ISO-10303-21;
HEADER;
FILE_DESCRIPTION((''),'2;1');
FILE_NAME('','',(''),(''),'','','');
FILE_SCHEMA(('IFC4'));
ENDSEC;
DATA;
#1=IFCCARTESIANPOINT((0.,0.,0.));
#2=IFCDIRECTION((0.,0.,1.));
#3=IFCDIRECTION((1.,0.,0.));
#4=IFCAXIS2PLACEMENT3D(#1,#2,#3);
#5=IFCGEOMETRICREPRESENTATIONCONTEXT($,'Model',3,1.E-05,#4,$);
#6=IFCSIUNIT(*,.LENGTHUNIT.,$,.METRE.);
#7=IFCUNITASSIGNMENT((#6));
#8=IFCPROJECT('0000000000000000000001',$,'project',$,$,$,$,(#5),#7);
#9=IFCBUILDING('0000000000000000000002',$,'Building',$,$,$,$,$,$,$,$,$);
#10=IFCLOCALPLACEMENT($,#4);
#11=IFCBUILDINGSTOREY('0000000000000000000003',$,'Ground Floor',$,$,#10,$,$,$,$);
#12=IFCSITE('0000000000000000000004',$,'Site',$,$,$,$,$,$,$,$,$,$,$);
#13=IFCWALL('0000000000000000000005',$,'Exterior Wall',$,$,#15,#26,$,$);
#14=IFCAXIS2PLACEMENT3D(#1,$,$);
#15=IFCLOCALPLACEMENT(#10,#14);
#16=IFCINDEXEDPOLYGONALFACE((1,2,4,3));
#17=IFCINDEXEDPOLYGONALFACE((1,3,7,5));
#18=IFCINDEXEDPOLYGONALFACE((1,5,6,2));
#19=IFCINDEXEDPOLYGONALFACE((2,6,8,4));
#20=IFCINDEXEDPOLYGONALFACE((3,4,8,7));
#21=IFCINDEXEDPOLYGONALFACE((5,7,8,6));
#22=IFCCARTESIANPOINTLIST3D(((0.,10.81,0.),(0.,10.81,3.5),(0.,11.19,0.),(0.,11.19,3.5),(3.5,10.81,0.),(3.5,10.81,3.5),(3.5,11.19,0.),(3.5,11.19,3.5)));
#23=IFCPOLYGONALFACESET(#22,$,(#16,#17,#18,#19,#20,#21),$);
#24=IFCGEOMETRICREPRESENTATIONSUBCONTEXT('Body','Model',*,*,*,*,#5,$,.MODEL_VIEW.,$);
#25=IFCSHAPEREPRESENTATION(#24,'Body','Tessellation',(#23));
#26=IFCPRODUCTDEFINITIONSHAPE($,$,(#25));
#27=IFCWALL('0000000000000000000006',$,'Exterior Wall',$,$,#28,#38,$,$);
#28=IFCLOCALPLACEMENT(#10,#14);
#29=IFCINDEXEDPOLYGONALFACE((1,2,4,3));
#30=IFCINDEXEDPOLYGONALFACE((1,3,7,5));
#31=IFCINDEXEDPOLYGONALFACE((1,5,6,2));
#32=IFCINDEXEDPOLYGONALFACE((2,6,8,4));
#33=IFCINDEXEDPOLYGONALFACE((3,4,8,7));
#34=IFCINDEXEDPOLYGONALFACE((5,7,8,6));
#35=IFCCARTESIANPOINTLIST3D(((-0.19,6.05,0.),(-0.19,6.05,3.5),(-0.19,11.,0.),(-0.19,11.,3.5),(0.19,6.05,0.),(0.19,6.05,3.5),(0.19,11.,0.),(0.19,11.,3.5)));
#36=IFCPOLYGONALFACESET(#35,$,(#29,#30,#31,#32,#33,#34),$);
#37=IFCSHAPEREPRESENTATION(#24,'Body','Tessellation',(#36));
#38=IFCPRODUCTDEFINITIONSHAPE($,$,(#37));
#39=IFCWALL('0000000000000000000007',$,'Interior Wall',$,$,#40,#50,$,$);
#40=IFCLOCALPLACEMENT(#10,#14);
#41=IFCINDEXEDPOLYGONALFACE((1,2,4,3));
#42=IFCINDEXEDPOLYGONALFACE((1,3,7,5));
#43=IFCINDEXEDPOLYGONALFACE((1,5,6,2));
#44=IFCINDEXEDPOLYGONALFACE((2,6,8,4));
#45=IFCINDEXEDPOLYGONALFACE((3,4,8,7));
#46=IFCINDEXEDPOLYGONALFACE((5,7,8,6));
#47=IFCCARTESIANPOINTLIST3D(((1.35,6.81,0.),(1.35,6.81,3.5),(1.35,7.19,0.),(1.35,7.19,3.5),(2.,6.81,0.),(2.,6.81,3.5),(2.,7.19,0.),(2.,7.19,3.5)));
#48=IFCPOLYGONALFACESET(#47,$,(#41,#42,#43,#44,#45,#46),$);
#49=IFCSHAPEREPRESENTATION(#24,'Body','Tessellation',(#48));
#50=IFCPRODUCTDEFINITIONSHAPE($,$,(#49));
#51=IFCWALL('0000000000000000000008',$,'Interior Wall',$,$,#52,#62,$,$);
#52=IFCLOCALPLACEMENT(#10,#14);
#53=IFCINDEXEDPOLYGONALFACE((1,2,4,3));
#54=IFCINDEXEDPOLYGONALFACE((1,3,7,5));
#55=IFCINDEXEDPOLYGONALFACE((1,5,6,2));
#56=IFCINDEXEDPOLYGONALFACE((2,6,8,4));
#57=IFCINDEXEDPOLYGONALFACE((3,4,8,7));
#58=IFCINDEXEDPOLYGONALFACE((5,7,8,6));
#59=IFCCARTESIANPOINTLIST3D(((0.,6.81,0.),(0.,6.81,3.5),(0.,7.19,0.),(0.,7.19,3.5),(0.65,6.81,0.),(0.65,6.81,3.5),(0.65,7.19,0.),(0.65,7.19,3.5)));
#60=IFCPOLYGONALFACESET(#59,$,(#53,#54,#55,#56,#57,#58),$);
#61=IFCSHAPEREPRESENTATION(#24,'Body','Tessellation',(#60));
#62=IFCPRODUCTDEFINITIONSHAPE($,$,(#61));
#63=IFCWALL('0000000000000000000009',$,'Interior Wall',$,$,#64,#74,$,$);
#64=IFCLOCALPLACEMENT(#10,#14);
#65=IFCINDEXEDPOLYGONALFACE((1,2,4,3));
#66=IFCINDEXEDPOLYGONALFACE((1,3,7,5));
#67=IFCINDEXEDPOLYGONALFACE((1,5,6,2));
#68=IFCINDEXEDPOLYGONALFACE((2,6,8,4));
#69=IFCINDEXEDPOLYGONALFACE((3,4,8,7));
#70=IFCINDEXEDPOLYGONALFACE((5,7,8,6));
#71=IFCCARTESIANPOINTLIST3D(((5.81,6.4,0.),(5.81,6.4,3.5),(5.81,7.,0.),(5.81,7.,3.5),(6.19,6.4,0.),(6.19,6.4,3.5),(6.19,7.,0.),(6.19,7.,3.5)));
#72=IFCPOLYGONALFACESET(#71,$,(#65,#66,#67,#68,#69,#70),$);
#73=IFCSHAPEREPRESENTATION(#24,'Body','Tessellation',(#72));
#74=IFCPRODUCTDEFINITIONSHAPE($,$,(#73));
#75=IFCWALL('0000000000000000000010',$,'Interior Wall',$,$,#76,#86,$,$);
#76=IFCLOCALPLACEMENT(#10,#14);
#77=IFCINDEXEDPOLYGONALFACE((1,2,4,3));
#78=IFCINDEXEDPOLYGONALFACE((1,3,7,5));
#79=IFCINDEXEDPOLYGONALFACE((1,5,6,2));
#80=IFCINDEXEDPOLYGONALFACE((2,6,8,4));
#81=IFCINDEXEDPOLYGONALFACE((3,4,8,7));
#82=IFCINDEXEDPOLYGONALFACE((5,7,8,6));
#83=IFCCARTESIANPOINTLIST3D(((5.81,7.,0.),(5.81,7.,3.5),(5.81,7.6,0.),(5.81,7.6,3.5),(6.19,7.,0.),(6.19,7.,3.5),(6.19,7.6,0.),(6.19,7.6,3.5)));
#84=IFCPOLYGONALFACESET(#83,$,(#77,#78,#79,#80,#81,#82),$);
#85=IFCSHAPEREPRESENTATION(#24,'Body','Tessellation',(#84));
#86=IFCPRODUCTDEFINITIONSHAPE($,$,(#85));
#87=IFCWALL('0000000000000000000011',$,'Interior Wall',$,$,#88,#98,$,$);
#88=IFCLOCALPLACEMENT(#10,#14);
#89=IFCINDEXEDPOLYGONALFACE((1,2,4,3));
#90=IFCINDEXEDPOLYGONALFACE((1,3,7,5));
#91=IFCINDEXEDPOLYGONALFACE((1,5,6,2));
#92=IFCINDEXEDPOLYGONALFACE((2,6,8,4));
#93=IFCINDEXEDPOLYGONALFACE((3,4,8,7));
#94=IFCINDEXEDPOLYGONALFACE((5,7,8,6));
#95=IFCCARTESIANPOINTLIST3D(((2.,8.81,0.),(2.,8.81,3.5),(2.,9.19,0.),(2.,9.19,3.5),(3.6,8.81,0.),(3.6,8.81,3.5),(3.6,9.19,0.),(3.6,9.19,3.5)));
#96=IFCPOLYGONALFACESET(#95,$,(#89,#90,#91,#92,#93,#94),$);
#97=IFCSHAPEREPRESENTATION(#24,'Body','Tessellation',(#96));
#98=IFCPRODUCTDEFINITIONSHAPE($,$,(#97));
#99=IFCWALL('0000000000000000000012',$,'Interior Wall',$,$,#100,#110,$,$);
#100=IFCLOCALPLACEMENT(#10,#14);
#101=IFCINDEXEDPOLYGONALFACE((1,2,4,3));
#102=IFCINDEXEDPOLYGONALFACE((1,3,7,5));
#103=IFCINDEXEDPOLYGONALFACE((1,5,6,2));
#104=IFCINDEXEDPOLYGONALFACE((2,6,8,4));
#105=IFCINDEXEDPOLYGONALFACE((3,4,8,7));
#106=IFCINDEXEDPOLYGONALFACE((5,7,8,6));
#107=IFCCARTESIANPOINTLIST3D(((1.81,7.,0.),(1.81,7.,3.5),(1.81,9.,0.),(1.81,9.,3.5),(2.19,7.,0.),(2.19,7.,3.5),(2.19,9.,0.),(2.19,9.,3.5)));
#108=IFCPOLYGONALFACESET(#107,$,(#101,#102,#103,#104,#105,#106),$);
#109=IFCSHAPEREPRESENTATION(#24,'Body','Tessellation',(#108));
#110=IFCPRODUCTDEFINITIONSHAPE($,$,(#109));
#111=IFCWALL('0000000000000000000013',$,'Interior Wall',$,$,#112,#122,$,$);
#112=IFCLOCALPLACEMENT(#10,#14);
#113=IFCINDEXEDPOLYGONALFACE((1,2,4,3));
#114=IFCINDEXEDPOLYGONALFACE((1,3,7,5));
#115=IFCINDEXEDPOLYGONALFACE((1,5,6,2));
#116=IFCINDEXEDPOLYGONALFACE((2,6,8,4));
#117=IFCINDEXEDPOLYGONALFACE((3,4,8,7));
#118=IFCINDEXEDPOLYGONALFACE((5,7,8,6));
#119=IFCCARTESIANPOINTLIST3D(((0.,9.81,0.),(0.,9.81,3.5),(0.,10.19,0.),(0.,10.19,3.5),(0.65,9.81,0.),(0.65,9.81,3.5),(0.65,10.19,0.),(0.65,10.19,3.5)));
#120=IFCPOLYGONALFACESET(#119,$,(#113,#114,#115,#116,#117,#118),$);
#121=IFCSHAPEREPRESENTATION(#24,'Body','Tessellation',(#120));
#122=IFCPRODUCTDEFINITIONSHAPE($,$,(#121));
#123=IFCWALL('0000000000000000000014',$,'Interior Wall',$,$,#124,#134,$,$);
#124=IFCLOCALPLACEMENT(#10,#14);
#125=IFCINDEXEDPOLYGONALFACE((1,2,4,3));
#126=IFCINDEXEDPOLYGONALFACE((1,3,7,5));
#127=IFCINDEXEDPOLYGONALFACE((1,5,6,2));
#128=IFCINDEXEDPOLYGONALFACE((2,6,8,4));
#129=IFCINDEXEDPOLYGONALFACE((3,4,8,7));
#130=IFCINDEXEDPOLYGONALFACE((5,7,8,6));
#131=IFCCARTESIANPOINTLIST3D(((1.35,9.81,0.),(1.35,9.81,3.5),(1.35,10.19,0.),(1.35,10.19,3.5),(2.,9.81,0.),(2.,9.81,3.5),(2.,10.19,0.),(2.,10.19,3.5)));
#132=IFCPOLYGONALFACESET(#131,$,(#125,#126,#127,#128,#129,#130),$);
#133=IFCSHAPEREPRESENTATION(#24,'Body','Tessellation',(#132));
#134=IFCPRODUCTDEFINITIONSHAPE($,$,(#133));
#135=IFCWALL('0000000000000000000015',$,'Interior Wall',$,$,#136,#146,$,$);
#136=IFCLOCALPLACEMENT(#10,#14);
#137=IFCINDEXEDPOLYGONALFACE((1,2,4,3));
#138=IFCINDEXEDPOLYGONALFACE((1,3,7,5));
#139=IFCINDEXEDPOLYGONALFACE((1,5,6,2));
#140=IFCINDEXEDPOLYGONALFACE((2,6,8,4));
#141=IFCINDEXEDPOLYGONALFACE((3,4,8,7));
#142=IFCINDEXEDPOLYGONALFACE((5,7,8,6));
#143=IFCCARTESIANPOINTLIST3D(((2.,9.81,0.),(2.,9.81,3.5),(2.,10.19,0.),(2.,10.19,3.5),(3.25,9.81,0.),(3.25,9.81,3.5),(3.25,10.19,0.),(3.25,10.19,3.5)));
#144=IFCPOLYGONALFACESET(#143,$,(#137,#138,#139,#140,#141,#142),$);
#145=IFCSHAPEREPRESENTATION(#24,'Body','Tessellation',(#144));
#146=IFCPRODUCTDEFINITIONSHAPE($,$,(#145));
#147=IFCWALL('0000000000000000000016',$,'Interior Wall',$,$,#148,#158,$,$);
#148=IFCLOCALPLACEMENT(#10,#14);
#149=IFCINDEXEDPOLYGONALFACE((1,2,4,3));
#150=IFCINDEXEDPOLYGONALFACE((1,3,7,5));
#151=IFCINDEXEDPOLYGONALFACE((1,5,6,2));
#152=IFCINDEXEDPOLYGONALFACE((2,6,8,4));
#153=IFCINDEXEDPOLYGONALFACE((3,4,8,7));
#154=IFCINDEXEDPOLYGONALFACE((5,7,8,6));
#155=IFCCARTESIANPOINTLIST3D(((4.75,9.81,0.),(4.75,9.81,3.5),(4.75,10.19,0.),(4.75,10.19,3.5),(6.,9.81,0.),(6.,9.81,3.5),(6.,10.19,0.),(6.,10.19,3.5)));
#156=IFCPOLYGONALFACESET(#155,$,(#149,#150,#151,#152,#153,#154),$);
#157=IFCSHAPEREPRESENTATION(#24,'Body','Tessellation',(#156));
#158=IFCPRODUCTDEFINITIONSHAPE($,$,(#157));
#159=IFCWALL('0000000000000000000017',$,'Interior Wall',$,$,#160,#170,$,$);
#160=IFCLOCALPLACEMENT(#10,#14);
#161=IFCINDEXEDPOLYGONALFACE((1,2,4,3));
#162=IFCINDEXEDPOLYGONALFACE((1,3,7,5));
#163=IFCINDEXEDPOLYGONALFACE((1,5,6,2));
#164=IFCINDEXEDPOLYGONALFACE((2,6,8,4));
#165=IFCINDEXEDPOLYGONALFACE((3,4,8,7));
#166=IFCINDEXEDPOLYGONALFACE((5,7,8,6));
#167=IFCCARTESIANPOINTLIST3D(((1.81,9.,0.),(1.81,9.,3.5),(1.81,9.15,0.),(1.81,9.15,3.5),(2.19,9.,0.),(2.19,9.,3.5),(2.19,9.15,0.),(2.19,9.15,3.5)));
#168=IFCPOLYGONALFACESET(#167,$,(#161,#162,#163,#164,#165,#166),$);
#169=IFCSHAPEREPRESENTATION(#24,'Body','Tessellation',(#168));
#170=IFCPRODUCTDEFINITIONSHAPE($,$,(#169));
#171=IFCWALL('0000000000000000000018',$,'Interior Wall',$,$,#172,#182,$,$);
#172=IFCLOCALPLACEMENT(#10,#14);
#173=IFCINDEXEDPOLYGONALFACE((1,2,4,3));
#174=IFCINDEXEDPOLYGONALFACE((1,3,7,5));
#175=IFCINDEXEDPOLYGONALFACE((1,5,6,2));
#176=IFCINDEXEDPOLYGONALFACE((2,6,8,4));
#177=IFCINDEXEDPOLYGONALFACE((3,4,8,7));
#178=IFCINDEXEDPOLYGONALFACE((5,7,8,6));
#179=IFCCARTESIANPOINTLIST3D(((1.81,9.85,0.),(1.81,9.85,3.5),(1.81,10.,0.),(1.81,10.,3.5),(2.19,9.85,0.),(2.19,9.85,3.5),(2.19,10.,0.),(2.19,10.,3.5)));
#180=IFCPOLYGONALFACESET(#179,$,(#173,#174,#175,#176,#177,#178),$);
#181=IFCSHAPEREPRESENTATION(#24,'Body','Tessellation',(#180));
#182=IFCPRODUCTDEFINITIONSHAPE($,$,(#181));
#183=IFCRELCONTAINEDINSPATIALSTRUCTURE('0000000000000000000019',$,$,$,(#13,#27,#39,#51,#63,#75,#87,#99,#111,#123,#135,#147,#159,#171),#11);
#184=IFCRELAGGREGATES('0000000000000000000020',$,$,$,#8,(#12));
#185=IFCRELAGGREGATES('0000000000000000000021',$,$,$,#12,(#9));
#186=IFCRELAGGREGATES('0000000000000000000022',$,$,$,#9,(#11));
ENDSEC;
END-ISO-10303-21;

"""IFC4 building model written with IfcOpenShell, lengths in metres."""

from ifc_helpers import new_model, si_unit, frame, origin_with_axes, place, context, subcontext, project, spatial, indexed_curve, outline, extrude, element, save


model = new_model("IFC4")

# Units and contexts
model_context = context("Model", 3, precision=1e-05, world=origin_with_axes())
body_context = subcontext(model_context, "Body", "Model", "MODEL_VIEW")
ifc_project = project(units=[si_unit("LENGTHUNIT", "METRE")], contexts=[model_context])

# Site, building, storey
site = spatial("IfcSite", under=ifc_project, Name="Site")
building = spatial("IfcBuilding", under=site, Name="Building")
storey_placement = place(None, origin_with_axes())
storey = spatial("IfcBuildingStorey", under=building, at=storey_placement, Name="Ground Floor")

# Walls
wall_1_placement = place(storey_placement, frame((3.5, 11.0, 0.0), z_axis=(0.0, 0.0, 1.0), x_axis=(-1.0, 0.0, 0.0)))
element("IfcWall", 1, at=wall_1_placement, inside=storey, Name="Exterior Wall", context=body_context, shape_type="SweptSolid", body=[
    extrude(outline(indexed_curve([(0.0, 0.0), (0.0, 0.38), (3.5, 0.38), (3.5, 0.0), (0.0, 0.0)], self_intersect=False)), frame((0.0, -0.19, 0.0), z_axis=(0.0, 0.0, 1.0), x_axis=(1.0, 0.0, 0.0)), (0.0, 0.0, 1.0), 3.5),
])
wall_2_placement = place(storey_placement, frame((0.0, 11.0, 0.0), z_axis=(0.0, 0.0, 1.0), x_axis=(0.0, -1.0, 0.0)))
element("IfcWall", 2, at=wall_2_placement, inside=storey, Name="Exterior Wall", context=body_context, shape_type="SweptSolid", body=[
    extrude(outline(indexed_curve([(0.0, 0.0), (0.0, 0.38), (4.95, 0.38), (4.95, 0.0), (0.0, 0.0)], self_intersect=False)), frame((0.0, -0.19, 0.0), z_axis=(0.0, 0.0, 1.0), x_axis=(1.0, 0.0, 0.0)), (0.0, 0.0, 1.0), 3.5),
])
for number, where, z_axis, x_axis, name in (
    (3, (2.0, 7.0, 0.0), (0.0, 0.0, 1.0), (-1.0, 0.0, 0.0), "Interior Wall"),
    (4, (0.65, 7.0, 0.0), (0.0, 0.0, 1.0), (-1.0, 0.0, 0.0), "Interior Wall"),
):
    element("IfcWall", number, at=place(storey_placement, frame(where, z_axis=z_axis, x_axis=x_axis)), inside=storey, Name=name, context=body_context, shape_type="SweptSolid", body=[
        extrude(outline(indexed_curve([(0.0, 0.0), (0.0, 0.38), (0.65, 0.38), (0.65, 0.0), (0.0, 0.0)], self_intersect=False)), frame((0.0, -0.19, 0.0), z_axis=(0.0, 0.0, 1.0), x_axis=(1.0, 0.0, 0.0)), (0.0, 0.0, 1.0), 3.5),
    ])
for number, where, z_axis, x_axis, name in (
    (5, (6.0, 6.4, 0.0), (0.0, 0.0, 1.0), (0.0, 1.0, 0.0), "Interior Wall"),
    (6, (6.0, 7.0, 0.0), (0.0, 0.0, 1.0), (0.0, 1.0, 0.0), "Interior Wall"),
):
    element("IfcWall", number, at=place(storey_placement, frame(where, z_axis=z_axis, x_axis=x_axis)), inside=storey, Name=name, context=body_context, shape_type="SweptSolid", body=[
        extrude(outline(indexed_curve([(0.0, 0.0), (0.0, 0.38), (0.6, 0.38), (0.6, 0.0), (0.0, 0.0)], self_intersect=False)), frame((0.0, -0.19, 0.0), z_axis=(0.0, 0.0, 1.0), x_axis=(1.0, 0.0, 0.0)), (0.0, 0.0, 1.0), 3.5),
    ])
wall_3_placement = place(storey_placement, frame((3.6, 9.0, 0.0), z_axis=(0.0, 0.0, 1.0), x_axis=(-1.0, 0.0, 0.0)))
element("IfcWall", 7, at=wall_3_placement, inside=storey, Name="Interior Wall", context=body_context, shape_type="SweptSolid", body=[
    extrude(outline(indexed_curve([(0.0, 0.0), (0.0, 0.38), (1.6, 0.38), (1.6, 0.0), (0.0, 0.0)], self_intersect=False)), frame((0.0, -0.19, 0.0), z_axis=(0.0, 0.0, 1.0), x_axis=(1.0, 0.0, 0.0)), (0.0, 0.0, 1.0), 3.5),
])
wall_4_placement = place(storey_placement, frame((2.0, 9.0, 0.0), z_axis=(0.0, 0.0, 1.0), x_axis=(0.0, -1.0, 0.0)))
element("IfcWall", 8, at=wall_4_placement, inside=storey, Name="Interior Wall", context=body_context, shape_type="SweptSolid", body=[
    extrude(outline(indexed_curve([(0.0, 0.0), (0.0, 0.38), (2.0, 0.38), (2.0, 0.0), (0.0, 0.0)], self_intersect=False)), frame((0.0, -0.19, 0.0), z_axis=(0.0, 0.0, 1.0), x_axis=(1.0, 0.0, 0.0)), (0.0, 0.0, 1.0), 3.5),
])
wall_5_placement = place(storey_placement, frame((0.0, 10.0, 0.0), z_axis=(0.0, 0.0, 1.0), x_axis=(1.0, 0.0, 0.0)))
element("IfcWall", 9, at=wall_5_placement, inside=storey, Name="Interior Wall", context=body_context, shape_type="SweptSolid", body=[
    extrude(outline(indexed_curve([(0.0, 0.0), (0.0, 0.38), (0.65, 0.38), (0.65, 0.0), (0.0, 0.0)], self_intersect=False)), frame((0.0, -0.19, 0.0), z_axis=(0.0, 0.0, 1.0), x_axis=(1.0, 0.0, 0.0)), (0.0, 0.0, 1.0), 3.5),
])
wall_6_placement = place(storey_placement, frame((1.35, 10.0, 0.0), z_axis=(0.0, 0.0, 1.0), x_axis=(1.0, 0.0, 0.0)))
element("IfcWall", 10, at=wall_6_placement, inside=storey, Name="Interior Wall", context=body_context, shape_type="SweptSolid", body=[
    extrude(outline(indexed_curve([(0.0, 0.0), (0.0, 0.38), (0.65, 0.38), (0.65, 0.0), (0.0, 0.0)], self_intersect=False)), frame((0.0, -0.19, 0.0), z_axis=(0.0, 0.0, 1.0), x_axis=(1.0, 0.0, 0.0)), (0.0, 0.0, 1.0), 3.5),
])
for number, where, z_axis, x_axis, name in (
    (11, (2.0, 10.0, 0.0), (0.0, 0.0, 1.0), (1.0, 0.0, 0.0), "Interior Wall"),
    (12, (4.75, 10.0, 0.0), (0.0, 0.0, 1.0), (1.0, 0.0, 0.0), "Interior Wall"),
):
    element("IfcWall", number, at=place(storey_placement, frame(where, z_axis=z_axis, x_axis=x_axis)), inside=storey, Name=name, context=body_context, shape_type="SweptSolid", body=[
        extrude(outline(indexed_curve([(0.0, 0.0), (0.0, 0.38), (1.25, 0.38), (1.25, 0.0), (0.0, 0.0)], self_intersect=False)), frame((0.0, -0.19, 0.0), z_axis=(0.0, 0.0, 1.0), x_axis=(1.0, 0.0, 0.0)), (0.0, 0.0, 1.0), 3.5),
    ])
for number, where, z_axis, x_axis, name in (
    (13, (2.0, 9.0, 0.0), (0.0, 0.0, 1.0), (0.0, 1.0, 0.0), "Interior Wall"),
    (14, (2.0, 9.85, 0.0), (0.0, 0.0, 1.0), (0.0, 1.0, 0.0), "Interior Wall"),
):
    element("IfcWall", number, at=place(storey_placement, frame(where, z_axis=z_axis, x_axis=x_axis)), inside=storey, Name=name, context=body_context, shape_type="SweptSolid", body=[
        extrude(outline(indexed_curve([(0.0, 0.0), (0.0, 0.38), (0.15, 0.38), (0.15, 0.0), (0.0, 0.0)], self_intersect=False)), frame((0.0, -0.19, 0.0), z_axis=(0.0, 0.0, 1.0), x_axis=(1.0, 0.0, 0.0)), (0.0, 0.0, 1.0), 3.5),
    ])

save(model, "model.ifc")
